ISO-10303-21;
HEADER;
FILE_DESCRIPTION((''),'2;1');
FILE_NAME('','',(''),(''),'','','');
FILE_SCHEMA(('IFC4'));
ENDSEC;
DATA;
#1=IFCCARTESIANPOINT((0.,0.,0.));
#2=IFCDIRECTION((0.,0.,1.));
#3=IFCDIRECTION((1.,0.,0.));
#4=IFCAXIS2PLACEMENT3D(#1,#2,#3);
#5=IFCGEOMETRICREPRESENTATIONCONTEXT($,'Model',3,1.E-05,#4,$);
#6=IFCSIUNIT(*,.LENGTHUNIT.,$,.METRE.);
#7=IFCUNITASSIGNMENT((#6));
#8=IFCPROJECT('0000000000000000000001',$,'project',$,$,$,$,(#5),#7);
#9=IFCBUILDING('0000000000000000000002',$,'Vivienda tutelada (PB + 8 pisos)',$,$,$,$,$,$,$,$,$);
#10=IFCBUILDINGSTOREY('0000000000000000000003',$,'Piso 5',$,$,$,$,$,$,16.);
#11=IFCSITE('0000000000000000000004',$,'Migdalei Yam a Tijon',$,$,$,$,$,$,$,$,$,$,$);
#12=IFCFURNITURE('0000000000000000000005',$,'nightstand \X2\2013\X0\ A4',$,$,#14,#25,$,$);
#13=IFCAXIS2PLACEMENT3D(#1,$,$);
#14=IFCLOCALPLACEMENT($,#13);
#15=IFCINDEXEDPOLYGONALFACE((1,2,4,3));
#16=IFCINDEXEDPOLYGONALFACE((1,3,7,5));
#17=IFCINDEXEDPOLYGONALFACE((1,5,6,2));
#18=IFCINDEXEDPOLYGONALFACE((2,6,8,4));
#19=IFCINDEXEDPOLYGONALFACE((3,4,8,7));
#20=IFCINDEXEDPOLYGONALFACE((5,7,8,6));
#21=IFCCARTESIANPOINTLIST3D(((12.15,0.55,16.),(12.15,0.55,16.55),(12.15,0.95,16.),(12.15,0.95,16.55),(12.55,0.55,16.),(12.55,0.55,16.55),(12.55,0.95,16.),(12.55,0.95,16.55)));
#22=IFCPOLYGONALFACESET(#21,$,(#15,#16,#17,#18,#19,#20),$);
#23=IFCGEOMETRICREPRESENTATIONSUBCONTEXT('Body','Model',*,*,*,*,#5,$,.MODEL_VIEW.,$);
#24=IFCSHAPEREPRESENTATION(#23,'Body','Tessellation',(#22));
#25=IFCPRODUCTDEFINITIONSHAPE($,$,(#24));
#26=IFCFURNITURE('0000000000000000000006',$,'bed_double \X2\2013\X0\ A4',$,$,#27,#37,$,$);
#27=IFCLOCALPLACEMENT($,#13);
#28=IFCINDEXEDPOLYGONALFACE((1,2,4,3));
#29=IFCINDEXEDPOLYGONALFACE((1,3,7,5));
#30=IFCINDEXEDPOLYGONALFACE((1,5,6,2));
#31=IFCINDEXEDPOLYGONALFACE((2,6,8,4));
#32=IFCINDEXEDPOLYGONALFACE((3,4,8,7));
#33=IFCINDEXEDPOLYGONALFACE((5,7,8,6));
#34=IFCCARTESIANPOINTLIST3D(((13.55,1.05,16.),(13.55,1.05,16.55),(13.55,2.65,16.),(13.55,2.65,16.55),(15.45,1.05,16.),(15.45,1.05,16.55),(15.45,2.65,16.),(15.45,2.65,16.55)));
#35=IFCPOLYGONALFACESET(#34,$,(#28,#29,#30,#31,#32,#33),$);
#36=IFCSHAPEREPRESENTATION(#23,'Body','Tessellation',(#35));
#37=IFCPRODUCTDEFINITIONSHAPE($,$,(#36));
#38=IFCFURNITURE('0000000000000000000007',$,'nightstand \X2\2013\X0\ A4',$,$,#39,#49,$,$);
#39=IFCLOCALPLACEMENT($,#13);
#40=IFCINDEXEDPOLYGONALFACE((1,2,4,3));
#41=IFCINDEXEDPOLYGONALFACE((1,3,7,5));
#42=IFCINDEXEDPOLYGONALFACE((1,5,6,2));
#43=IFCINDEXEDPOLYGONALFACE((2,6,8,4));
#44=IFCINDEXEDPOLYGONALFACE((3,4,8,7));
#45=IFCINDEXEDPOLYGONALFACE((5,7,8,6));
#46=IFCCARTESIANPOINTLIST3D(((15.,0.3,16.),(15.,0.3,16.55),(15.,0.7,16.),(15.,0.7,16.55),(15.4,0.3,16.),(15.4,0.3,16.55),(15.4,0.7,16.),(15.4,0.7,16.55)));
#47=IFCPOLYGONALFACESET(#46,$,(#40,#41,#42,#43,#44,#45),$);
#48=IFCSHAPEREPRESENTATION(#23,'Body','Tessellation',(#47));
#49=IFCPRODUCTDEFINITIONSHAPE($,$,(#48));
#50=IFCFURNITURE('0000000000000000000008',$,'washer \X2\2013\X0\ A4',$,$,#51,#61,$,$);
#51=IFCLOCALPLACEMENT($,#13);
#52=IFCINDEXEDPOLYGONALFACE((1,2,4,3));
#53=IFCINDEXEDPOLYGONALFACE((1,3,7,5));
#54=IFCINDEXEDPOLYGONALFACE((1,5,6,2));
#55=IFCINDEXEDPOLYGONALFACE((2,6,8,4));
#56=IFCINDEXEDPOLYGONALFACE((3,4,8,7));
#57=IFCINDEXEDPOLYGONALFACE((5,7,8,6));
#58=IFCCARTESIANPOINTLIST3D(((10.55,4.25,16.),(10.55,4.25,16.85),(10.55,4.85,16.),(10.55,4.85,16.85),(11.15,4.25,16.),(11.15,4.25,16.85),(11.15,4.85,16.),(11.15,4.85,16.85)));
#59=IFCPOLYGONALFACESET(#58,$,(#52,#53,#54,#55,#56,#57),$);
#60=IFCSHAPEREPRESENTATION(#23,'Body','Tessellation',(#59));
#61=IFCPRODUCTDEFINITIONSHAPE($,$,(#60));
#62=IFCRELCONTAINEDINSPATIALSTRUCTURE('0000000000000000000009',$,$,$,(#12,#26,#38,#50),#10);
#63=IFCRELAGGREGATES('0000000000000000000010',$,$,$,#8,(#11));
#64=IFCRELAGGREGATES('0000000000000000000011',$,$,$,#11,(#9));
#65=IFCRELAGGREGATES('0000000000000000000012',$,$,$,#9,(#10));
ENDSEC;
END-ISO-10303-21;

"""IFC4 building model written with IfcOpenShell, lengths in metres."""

from ifc_helpers import new_model, si_unit, frame, origin_with_axes, context, subcontext, project, spatial, line, indexed_curve, outline, extrude, element, save


model = new_model("IFC4")

# Units and contexts
model_context = context("Model", 3, precision=1e-05, world=origin_with_axes())
body_context = subcontext(model_context, "Body", "Model", "MODEL_VIEW")
ifc_project = project(units=[si_unit("LENGTHUNIT", "METRE")], contexts=[model_context])

# Site, building, storey
site = spatial("IfcSite", under=ifc_project, Name="Migdalei Yam a Tijon")
building = spatial("IfcBuilding", under=site, Name="Vivienda tutelada (PB + 8 pisos)")
storey = spatial("IfcBuildingStorey", under=building, Name="Piso 5", Elevation=16.0)

# Furniture
element("IfcFurniture", 1, inside=storey, Name="nightstand – A4", context=body_context, shape_type="SweptSolid", body=[
    extrude(outline(indexed_curve([(0.0, 0.0), (0.4, 0.0), (0.4, 0.4), (0.0, 0.4)], segments=[line(1, 2, 3, 4, 1)])), frame((12.15, 0.55, 16.0), z_axis=(0.0, 0.0, 1.0), x_axis=(1.0, 0.0, 0.0)), (0.0, 0.0, 1.0), 0.55),
])
element("IfcFurniture", 2, inside=storey, Name="bed_double – A4", context=body_context, shape_type="SweptSolid", body=[
    extrude(outline(indexed_curve([(0.0, 0.0), (1.9, 0.0), (1.9, 1.6), (0.0, 1.6)], segments=[line(1, 2, 3, 4, 1)])), frame((13.55, 1.05, 16.0), z_axis=(0.0, 0.0, 1.0), x_axis=(1.0, 0.0, 0.0)), (0.0, 0.0, 1.0), 0.55),
])
element("IfcFurniture", 3, inside=storey, Name="nightstand – A4", context=body_context, shape_type="SweptSolid", body=[
    extrude(outline(indexed_curve([(0.0, 0.0), (0.4, 0.0), (0.4, 0.4), (0.0, 0.4)], segments=[line(1, 2, 3, 4, 1)])), frame((15.0, 0.3, 16.0), z_axis=(0.0, 0.0, 1.0), x_axis=(1.0, 0.0, 0.0)), (0.0, 0.0, 1.0), 0.55),
])
element("IfcFurniture", 4, inside=storey, Name="washer – A4", context=body_context, shape_type="SweptSolid", body=[
    extrude(outline(indexed_curve([(0.0, 0.0), (0.6, 0.0), (0.6, 0.6), (0.0, 0.6)], segments=[line(1, 2, 3, 4, 1)])), frame((10.55, 4.25, 16.0), z_axis=(0.0, 0.0, 1.0), x_axis=(1.0, 0.0, 0.0)), (0.0, 0.0, 1.0), 0.85),
])

save(model, "model.ifc")
